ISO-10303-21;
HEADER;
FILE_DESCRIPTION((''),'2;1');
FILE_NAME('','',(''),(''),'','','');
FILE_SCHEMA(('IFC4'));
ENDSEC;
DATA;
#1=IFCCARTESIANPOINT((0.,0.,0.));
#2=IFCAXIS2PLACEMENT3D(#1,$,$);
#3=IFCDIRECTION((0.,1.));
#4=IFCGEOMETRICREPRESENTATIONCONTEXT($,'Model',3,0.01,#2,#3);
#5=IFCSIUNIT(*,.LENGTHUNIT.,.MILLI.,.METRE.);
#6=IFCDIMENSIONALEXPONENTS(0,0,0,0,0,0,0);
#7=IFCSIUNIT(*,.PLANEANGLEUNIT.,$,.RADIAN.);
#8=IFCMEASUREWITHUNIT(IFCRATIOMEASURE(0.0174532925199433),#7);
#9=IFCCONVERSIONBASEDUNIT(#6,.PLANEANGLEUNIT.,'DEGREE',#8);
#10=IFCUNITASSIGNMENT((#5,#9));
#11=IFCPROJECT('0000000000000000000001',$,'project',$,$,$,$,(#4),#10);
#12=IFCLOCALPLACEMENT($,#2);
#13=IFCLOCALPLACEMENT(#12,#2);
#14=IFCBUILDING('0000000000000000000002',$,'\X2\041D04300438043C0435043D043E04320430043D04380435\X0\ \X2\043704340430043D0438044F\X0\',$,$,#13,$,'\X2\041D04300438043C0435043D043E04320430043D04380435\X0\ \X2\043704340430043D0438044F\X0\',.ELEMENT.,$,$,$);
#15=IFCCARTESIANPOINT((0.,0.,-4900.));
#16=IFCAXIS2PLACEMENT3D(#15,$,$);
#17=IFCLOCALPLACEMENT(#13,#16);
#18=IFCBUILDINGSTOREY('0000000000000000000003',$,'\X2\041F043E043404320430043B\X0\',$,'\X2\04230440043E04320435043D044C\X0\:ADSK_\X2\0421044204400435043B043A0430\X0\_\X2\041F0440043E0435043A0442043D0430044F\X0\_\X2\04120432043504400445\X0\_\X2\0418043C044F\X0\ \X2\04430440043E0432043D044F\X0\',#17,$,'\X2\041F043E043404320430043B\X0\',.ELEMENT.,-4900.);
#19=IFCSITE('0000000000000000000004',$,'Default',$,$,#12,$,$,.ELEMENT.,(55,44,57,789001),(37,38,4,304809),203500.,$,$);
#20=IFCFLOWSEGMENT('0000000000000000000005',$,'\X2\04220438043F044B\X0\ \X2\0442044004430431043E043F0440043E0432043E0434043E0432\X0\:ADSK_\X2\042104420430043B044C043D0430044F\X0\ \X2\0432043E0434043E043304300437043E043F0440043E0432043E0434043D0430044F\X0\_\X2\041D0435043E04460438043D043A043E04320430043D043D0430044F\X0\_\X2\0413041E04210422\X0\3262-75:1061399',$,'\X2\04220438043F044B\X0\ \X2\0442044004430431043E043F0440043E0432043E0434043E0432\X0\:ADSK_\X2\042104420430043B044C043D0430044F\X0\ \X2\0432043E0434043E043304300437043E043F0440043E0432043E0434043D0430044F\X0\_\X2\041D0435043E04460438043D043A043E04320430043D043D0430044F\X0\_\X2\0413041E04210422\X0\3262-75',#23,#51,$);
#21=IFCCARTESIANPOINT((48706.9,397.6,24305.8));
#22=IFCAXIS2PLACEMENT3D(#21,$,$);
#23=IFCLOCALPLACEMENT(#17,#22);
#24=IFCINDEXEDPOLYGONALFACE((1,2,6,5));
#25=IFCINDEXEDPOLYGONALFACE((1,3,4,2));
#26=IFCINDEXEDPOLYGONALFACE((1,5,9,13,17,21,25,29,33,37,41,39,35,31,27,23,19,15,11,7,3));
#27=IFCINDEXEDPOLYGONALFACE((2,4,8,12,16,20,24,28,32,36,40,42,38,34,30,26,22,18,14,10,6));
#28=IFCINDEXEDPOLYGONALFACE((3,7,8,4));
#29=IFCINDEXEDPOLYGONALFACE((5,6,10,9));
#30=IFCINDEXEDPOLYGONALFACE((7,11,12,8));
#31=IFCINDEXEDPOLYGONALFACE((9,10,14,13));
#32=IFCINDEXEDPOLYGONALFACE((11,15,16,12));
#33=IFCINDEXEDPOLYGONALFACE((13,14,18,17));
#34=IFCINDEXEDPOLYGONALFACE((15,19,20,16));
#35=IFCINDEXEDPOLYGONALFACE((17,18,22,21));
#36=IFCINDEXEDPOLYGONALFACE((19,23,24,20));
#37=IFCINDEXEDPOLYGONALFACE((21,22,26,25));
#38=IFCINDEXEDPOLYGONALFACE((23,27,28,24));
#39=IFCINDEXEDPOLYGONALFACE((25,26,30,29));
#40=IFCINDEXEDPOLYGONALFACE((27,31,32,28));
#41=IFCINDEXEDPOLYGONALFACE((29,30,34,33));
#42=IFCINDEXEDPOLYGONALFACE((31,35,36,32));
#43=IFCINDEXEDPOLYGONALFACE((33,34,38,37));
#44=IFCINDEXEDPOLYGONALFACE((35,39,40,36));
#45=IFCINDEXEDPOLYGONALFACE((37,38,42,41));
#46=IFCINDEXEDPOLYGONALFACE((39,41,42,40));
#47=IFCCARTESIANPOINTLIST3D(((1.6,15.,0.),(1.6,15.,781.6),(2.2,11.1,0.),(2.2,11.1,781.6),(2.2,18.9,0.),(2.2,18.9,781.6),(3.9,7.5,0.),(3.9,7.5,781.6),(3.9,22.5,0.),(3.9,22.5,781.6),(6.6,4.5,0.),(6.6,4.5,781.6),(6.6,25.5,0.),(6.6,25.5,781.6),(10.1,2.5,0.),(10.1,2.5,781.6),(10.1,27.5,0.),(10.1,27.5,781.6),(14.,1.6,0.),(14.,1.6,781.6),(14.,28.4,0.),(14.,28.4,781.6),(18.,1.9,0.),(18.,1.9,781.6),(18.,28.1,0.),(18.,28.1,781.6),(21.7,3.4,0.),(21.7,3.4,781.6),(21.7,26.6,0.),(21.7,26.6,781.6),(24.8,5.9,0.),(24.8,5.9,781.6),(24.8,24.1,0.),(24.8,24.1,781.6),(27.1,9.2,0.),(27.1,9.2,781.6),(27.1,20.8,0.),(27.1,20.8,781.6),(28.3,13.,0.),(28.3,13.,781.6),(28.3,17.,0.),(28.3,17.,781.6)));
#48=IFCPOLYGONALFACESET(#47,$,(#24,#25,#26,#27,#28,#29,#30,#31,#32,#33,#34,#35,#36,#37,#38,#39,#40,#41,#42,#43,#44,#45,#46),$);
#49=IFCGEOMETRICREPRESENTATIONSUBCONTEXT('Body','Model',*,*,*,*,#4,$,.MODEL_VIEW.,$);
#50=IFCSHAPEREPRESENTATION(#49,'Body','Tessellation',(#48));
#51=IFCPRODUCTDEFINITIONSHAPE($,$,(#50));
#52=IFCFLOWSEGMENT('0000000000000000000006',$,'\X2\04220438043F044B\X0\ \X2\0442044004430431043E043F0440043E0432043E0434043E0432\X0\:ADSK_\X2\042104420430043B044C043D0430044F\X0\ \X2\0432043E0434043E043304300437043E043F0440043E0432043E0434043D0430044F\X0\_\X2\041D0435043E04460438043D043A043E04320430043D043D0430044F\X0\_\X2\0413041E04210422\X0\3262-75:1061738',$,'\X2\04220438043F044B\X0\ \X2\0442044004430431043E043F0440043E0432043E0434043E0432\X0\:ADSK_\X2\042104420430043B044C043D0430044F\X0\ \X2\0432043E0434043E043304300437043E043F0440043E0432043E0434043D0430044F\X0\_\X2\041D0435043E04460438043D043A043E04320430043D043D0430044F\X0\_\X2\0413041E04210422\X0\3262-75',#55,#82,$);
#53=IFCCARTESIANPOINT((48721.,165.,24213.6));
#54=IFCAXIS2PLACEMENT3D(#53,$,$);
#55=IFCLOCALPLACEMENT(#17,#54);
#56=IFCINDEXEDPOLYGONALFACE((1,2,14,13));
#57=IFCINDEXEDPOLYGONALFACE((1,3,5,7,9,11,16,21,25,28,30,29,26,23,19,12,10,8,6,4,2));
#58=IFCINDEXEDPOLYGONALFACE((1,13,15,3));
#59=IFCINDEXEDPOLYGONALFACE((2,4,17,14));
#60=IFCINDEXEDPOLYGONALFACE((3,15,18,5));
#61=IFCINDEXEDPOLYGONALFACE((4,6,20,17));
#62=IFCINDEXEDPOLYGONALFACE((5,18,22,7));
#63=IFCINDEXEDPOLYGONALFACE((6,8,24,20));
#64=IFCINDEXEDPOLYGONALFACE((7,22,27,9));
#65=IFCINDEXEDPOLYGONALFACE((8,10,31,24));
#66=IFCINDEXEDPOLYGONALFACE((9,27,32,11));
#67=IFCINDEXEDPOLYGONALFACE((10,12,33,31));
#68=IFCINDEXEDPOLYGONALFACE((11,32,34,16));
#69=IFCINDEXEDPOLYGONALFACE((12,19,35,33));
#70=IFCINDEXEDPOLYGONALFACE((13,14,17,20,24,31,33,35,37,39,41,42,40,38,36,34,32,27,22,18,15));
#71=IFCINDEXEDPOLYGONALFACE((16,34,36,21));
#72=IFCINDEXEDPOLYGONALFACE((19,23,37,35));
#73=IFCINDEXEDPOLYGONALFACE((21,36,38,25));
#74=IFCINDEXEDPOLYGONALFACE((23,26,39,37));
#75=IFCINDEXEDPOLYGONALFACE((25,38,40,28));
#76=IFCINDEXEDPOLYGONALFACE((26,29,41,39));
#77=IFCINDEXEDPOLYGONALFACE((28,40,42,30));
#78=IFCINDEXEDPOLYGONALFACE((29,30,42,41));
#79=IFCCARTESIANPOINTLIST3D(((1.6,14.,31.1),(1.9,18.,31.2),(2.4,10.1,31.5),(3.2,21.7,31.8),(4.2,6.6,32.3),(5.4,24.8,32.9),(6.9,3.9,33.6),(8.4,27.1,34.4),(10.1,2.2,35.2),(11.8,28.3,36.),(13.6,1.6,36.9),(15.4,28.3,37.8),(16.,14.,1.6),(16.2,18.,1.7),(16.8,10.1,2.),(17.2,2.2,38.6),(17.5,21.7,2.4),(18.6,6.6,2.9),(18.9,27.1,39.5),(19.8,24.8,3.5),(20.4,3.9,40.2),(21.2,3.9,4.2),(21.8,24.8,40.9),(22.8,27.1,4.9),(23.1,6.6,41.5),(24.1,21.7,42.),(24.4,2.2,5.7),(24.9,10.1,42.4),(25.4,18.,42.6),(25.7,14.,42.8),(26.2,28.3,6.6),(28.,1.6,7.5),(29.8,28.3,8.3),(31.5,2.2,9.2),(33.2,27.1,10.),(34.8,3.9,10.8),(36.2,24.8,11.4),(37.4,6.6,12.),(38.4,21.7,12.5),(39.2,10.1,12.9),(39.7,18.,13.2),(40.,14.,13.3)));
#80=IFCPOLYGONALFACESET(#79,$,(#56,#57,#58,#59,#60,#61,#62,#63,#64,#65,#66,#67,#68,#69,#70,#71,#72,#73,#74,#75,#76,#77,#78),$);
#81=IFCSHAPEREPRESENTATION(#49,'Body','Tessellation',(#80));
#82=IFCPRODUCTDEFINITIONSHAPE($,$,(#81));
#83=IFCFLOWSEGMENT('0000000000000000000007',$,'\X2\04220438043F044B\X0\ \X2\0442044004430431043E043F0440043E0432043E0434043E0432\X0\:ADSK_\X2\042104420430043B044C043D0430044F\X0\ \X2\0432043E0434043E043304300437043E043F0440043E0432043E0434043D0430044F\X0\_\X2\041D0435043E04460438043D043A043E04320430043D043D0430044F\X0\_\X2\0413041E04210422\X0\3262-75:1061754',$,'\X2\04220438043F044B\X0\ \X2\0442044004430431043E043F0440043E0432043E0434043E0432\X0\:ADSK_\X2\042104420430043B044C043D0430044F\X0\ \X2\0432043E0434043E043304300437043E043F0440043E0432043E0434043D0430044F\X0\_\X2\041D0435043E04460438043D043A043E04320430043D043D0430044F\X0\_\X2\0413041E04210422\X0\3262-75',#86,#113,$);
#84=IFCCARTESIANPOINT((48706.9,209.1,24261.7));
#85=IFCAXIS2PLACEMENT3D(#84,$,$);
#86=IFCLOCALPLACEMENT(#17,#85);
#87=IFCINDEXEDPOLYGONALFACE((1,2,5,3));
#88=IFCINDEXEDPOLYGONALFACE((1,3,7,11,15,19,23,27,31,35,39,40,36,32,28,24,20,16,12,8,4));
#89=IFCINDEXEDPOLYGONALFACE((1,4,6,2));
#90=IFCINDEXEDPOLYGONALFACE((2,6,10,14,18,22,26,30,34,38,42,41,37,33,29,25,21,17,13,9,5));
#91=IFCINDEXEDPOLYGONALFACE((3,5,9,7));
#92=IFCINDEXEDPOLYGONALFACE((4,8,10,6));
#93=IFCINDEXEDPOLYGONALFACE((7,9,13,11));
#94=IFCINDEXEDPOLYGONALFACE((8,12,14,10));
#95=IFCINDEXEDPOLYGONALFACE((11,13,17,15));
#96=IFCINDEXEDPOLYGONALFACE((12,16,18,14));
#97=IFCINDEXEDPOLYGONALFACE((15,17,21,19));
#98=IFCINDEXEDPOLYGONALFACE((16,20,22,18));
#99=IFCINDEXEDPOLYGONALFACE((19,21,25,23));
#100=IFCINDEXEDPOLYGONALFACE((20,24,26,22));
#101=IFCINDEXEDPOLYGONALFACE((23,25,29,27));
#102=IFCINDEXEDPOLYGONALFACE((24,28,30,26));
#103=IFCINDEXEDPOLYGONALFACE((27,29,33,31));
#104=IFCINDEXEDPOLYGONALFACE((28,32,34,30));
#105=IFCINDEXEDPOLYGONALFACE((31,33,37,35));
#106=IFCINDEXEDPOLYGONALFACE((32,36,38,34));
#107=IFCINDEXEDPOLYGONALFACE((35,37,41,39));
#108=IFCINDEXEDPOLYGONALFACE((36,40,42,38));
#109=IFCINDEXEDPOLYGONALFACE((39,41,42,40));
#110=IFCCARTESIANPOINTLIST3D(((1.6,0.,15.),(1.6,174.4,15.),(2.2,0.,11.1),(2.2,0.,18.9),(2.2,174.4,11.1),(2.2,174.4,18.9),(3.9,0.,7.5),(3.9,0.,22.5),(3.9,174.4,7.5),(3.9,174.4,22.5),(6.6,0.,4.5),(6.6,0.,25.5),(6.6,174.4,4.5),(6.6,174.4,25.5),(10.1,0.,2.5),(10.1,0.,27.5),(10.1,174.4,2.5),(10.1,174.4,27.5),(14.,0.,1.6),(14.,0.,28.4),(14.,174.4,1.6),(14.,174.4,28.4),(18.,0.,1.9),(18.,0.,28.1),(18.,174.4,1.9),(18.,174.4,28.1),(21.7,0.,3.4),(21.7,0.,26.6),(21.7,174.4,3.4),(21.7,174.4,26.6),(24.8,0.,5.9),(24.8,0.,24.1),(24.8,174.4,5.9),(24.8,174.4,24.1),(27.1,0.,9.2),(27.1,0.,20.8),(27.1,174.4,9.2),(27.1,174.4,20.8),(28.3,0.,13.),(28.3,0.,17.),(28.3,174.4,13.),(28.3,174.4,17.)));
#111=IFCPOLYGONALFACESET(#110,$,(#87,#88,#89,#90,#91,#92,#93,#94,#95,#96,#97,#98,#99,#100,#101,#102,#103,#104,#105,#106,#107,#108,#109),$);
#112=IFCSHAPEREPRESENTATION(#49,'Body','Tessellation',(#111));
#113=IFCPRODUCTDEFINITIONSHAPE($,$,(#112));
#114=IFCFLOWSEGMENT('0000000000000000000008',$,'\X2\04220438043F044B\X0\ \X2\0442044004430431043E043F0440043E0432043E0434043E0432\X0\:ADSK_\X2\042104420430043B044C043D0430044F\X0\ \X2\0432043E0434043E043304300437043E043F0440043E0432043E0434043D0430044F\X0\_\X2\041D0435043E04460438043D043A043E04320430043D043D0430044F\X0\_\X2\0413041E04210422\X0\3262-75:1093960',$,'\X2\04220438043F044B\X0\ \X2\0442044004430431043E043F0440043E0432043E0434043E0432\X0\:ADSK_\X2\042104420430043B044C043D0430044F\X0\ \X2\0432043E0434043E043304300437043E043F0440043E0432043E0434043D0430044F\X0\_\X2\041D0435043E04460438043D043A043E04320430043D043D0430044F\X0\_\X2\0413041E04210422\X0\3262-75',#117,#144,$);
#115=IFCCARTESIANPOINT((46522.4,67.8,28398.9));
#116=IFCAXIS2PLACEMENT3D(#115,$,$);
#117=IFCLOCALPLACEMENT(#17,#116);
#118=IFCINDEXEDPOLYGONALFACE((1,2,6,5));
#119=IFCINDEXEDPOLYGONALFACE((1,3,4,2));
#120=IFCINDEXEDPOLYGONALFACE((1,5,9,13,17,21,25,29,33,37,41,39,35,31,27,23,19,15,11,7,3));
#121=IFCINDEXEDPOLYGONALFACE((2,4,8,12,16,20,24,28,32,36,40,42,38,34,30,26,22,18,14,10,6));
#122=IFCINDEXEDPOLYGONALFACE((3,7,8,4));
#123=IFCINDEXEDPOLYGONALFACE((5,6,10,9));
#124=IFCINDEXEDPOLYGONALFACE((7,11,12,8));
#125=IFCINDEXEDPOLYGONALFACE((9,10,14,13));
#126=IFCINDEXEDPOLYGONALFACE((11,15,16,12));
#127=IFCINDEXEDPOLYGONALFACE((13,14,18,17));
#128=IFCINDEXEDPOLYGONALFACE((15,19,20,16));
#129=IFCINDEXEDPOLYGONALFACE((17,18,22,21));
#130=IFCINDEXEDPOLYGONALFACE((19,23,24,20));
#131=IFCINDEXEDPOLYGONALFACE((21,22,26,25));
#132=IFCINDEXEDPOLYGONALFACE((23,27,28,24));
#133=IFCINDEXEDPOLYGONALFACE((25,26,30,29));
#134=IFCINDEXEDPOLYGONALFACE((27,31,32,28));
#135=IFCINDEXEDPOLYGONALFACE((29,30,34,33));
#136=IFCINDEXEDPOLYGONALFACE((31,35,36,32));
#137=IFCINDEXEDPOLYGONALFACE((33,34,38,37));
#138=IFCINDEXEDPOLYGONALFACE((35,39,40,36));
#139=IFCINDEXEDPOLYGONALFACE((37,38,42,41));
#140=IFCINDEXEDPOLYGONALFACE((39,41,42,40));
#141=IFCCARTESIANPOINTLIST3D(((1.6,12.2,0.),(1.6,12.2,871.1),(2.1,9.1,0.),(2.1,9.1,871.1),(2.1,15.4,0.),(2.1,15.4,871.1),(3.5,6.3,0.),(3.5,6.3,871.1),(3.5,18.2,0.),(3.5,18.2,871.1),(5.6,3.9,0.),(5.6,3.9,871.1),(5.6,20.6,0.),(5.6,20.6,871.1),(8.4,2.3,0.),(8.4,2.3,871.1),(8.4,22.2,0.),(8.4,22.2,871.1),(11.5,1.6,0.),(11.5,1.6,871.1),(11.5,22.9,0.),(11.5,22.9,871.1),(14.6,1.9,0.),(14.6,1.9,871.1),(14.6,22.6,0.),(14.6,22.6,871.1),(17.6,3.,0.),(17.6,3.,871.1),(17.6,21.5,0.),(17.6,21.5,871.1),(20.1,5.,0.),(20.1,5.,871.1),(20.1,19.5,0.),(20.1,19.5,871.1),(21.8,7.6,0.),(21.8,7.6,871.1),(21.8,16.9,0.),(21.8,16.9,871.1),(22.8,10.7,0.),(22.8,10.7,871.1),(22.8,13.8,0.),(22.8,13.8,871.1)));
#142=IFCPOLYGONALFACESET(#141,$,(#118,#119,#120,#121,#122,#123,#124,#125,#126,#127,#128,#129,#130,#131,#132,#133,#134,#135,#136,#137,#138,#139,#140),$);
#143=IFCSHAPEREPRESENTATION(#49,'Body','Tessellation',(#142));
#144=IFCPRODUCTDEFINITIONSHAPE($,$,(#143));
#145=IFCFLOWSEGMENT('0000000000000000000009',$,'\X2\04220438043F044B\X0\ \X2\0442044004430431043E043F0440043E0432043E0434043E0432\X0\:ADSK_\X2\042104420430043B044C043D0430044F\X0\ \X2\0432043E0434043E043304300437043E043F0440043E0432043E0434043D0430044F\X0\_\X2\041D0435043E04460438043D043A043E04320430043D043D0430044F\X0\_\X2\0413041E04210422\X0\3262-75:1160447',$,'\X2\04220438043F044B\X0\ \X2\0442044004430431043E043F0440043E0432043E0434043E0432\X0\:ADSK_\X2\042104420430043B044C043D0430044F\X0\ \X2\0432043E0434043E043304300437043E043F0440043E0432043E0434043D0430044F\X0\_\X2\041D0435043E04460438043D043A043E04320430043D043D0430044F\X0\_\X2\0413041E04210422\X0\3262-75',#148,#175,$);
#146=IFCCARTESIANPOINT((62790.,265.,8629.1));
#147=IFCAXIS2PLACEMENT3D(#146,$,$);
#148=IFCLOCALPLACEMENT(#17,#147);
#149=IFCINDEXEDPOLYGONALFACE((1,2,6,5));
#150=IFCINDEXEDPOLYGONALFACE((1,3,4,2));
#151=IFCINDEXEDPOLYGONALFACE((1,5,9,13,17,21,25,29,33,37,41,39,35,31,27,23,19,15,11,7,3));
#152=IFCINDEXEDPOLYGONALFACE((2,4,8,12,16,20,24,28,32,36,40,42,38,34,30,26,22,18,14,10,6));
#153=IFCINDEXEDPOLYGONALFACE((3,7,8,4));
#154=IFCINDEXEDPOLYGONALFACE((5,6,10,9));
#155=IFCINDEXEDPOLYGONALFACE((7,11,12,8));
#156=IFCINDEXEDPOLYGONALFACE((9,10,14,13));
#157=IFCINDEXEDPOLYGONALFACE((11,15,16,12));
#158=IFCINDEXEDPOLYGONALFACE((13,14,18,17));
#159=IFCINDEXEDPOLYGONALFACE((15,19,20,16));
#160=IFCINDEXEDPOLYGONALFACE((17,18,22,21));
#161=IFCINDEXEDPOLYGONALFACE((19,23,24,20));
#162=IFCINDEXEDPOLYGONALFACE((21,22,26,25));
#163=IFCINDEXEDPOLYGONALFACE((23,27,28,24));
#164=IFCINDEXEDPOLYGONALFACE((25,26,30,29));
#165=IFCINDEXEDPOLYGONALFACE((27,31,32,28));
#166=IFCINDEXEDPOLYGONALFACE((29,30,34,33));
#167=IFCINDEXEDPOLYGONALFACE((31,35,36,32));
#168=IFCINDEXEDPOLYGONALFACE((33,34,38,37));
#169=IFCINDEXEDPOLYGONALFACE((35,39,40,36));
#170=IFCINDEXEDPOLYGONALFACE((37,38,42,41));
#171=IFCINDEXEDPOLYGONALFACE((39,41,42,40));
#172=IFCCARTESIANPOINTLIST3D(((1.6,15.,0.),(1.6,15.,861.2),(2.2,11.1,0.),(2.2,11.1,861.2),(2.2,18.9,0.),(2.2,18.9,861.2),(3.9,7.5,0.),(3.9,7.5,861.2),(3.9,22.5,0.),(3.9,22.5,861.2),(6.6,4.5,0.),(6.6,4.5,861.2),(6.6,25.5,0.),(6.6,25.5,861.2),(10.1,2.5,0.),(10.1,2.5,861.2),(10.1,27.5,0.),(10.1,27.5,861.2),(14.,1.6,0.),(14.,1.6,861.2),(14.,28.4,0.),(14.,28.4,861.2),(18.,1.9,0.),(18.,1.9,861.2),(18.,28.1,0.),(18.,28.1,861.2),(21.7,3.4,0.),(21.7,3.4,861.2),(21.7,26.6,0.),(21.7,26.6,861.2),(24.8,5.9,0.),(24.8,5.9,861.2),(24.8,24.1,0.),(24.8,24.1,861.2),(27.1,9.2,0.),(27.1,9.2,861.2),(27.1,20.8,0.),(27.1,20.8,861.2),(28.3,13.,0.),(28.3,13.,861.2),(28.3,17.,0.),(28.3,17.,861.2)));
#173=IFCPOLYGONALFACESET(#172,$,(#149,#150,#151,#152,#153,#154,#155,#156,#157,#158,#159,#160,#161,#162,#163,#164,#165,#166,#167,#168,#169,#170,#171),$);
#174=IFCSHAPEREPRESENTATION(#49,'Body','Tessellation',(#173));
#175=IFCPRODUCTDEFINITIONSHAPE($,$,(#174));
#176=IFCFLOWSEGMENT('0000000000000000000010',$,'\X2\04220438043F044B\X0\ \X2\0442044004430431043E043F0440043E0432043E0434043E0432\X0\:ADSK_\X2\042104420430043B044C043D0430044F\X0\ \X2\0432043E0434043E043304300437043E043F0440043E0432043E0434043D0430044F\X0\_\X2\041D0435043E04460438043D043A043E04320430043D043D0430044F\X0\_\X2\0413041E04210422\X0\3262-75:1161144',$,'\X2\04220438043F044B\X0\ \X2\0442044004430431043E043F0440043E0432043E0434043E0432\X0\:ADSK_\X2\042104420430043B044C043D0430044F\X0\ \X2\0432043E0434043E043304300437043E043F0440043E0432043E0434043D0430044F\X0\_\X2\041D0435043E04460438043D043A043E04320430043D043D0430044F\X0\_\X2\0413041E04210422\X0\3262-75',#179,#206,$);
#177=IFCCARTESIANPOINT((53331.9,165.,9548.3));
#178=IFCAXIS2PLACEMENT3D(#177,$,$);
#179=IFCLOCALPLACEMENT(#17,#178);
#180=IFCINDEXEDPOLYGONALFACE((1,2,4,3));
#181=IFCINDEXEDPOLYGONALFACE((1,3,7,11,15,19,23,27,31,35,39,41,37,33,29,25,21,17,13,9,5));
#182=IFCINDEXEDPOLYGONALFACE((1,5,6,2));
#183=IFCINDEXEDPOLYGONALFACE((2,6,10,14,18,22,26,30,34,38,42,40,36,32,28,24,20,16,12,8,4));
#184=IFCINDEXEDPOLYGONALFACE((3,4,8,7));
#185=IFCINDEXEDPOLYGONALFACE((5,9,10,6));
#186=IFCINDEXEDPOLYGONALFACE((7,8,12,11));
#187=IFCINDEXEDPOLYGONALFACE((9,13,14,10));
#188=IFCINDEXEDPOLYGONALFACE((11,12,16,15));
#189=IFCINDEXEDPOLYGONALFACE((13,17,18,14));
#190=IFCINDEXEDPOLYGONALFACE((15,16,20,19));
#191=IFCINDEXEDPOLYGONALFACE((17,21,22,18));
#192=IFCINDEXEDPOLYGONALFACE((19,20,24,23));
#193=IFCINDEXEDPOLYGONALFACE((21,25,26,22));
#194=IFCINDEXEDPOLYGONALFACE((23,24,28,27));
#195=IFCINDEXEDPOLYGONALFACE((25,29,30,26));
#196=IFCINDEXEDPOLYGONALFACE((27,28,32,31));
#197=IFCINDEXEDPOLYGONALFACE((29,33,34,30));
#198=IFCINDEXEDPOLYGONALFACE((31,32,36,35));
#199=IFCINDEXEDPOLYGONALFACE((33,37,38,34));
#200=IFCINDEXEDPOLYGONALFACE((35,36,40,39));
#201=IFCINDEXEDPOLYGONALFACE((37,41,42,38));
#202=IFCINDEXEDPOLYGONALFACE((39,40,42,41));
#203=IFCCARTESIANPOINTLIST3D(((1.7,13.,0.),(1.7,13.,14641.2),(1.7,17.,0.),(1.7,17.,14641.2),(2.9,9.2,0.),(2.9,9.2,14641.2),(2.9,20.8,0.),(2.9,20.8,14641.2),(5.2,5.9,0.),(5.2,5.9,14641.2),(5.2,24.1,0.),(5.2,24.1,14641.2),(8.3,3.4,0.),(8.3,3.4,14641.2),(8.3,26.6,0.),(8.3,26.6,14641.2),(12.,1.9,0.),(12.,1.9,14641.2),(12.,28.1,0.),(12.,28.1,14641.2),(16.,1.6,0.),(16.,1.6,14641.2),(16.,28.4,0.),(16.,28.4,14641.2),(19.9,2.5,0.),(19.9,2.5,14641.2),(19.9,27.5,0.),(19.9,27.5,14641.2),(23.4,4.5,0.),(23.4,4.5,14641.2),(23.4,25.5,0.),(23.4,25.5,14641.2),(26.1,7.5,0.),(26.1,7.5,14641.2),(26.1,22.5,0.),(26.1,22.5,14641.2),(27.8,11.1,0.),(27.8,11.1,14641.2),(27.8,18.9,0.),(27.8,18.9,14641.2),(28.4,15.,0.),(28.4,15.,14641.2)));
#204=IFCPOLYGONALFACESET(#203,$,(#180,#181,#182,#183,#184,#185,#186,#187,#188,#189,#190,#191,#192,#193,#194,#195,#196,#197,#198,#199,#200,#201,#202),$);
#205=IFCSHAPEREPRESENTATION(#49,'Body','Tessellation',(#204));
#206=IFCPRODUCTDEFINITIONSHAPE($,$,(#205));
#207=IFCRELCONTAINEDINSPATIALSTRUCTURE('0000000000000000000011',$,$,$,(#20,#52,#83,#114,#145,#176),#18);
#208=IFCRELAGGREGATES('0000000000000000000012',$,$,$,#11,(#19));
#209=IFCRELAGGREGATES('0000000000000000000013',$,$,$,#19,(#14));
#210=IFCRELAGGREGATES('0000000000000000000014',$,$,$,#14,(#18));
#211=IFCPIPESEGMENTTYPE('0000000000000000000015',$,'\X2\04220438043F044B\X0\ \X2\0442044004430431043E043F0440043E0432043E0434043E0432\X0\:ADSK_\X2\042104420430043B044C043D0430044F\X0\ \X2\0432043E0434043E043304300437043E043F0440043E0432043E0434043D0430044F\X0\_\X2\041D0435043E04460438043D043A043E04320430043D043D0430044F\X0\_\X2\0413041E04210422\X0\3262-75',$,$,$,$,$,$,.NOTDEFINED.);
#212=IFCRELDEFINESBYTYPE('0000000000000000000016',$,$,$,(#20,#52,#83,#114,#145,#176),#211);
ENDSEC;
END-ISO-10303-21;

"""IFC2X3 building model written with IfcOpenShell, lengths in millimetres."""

from ifc_helpers import new_model, entity, si_unit, converted_unit, direction, frame, origin, origin_2d_with_axis, place, context, subcontext, project, spatial, circle, extrude, type_object, element, save


model = new_model("IFC2X3")

# Units and contexts
model_context = context("Model", 3, precision=0.01, world=origin(), true_north=direction((0.0, 1.0)))
body_context = subcontext(model_context, "Body", "Model", "MODEL_VIEW")
ifc_project = project(units=[si_unit("LENGTHUNIT", "METRE", prefix="MILLI"), converted_unit("PLANEANGLEUNIT", "DEGREE", entity("IfcRatioMeasure", 0.0174532925199433), si_unit("PLANEANGLEUNIT", "RADIAN"), dimensions=[0, 0, 0, 0, 0, 0, 0])], contexts=[model_context])

# Site, building, storey
site_placement = place(None, origin())
site = spatial("IfcSite", under=ifc_project, at=site_placement, Name="Default", CompositionType="ELEMENT", RefLatitude=(55, 44, 57, 789001), RefLongitude=(37, 38, 4, 304809), RefElevation=203500.0)
building_placement = place(site_placement, origin())
building = spatial("IfcBuilding", under=site, at=building_placement, Name="Наименование здания", LongName="Наименование здания", CompositionType="ELEMENT")
storey_placement = place(building_placement, frame((0.0, 0.0, -4900.0)))
storey = spatial("IfcBuildingStorey", under=building, at=storey_placement, Name="Подвал", ObjectType="Уровень:ADSK_Стрелка_Проектная_Вверх_Имя уровня", LongName="Подвал", CompositionType="ELEMENT", Elevation=-4900.0)

# Flow segments
pipe_segment_type = type_object("IfcPipeSegmentType", Name="Типы трубопроводов:ADSK_Стальная водогазопроводная_Неоцинкованная_ГОСТ3262-75", PredefinedType="NOTDEFINED")
flow_segment_1_placement = place(storey_placement, frame((48706.9, 397.6, 24305.8)))
element("IfcFlowSegment", 1, at=flow_segment_1_placement, inside=storey, type_object=pipe_segment_type, Name="Типы трубопроводов:ADSK_Стальная водогазопроводная_Неоцинкованная_ГОСТ3262-75:1061399", ObjectType="Типы трубопроводов:ADSK_Стальная водогазопроводная_Неоцинкованная_ГОСТ3262-75", context=body_context, shape_type="SweptSolid", body=[
    extrude(circle(Radius=13.4, at=origin_2d_with_axis()), frame((15.0, 15.0, 0.0), z_axis=(0.0, 0.0, 1.0), x_axis=(-1.0, 0.0, 0.0)), (0.0, 0.0, 1.0), 781.6),
])
flow_segment_2_placement = place(storey_placement, frame((48721.0, 165.0, 24213.6)))
element("IfcFlowSegment", 2, at=flow_segment_2_placement, inside=storey, type_object=pipe_segment_type, Name="Типы трубопроводов:ADSK_Стальная водогазопроводная_Неоцинкованная_ГОСТ3262-75:1061738", ObjectType="Типы трубопроводов:ADSK_Стальная водогазопроводная_Неоцинкованная_ГОСТ3262-75", context=body_context, shape_type="SweptSolid", body=[
    extrude(circle(Radius=13.4, at=origin_2d_with_axis()), frame((28.0, 15.0, 7.5), z_axis=(-0.43765, 0.0, 0.899146), x_axis=(0.0, -1.0, 0.0)), (0.0, 0.0, 1.0), 32.8),
])
flow_segment_3_placement = place(storey_placement, frame((48706.9, 209.1, 24261.7)))
element("IfcFlowSegment", 3, at=flow_segment_3_placement, inside=storey, type_object=pipe_segment_type, Name="Типы трубопроводов:ADSK_Стальная водогазопроводная_Неоцинкованная_ГОСТ3262-75:1061754", ObjectType="Типы трубопроводов:ADSK_Стальная водогазопроводная_Неоцинкованная_ГОСТ3262-75", context=body_context, shape_type="SweptSolid", body=[
    extrude(circle(Radius=13.4, at=origin_2d_with_axis()), frame((15.0, 0.0, 15.0), z_axis=(0.0, 1.0, 0.0), x_axis=(-1.0, 0.0, 0.0)), (0.0, 0.0, 1.0), 174.4),
])
flow_segment_4_placement = place(storey_placement, frame((46522.4, 67.8, 28398.9)))
element("IfcFlowSegment", 4, at=flow_segment_4_placement, inside=storey, type_object=pipe_segment_type, Name="Типы трубопроводов:ADSK_Стальная водогазопроводная_Неоцинкованная_ГОСТ3262-75:1093960", ObjectType="Типы трубопроводов:ADSK_Стальная водогазопроводная_Неоцинкованная_ГОСТ3262-75", context=body_context, shape_type="SweptSolid", body=[
    extrude(circle(Radius=10.7, at=origin_2d_with_axis()), frame((12.2, 12.2, 0.0), z_axis=(0.0, 0.0, 1.0), x_axis=(-1.0, 0.0, 0.0)), (0.0, 0.0, 1.0), 871.1),
])
flow_segment_5_placement = place(storey_placement, frame((62790.0, 265.0, 8629.1)))
element("IfcFlowSegment", 5, at=flow_segment_5_placement, inside=storey, type_object=pipe_segment_type, Name="Типы трубопроводов:ADSK_Стальная водогазопроводная_Неоцинкованная_ГОСТ3262-75:1160447", ObjectType="Типы трубопроводов:ADSK_Стальная водогазопроводная_Неоцинкованная_ГОСТ3262-75", context=body_context, shape_type="SweptSolid", body=[
    extrude(circle(Radius=13.4, at=origin_2d_with_axis()), frame((15.0, 15.0, 0.0), z_axis=(0.0, 0.0, 1.0), x_axis=(-1.0, 0.0, 0.0)), (0.0, 0.0, 1.0), 861.2),
])
flow_segment_6_placement = place(storey_placement, frame((53331.9, 165.0, 9548.3)))
element("IfcFlowSegment", 6, at=flow_segment_6_placement, inside=storey, type_object=pipe_segment_type, Name="Типы трубопроводов:ADSK_Стальная водогазопроводная_Неоцинкованная_ГОСТ3262-75:1161144", ObjectType="Типы трубопроводов:ADSK_Стальная водогазопроводная_Неоцинкованная_ГОСТ3262-75", context=body_context, shape_type="SweptSolid", body=[
    extrude(circle(Radius=13.4, at=origin_2d_with_axis()), frame((15.0, 15.0, 0.0)), (0.0, 0.0, 1.0), 14641.2),
])

save(model, "model.ifc")
